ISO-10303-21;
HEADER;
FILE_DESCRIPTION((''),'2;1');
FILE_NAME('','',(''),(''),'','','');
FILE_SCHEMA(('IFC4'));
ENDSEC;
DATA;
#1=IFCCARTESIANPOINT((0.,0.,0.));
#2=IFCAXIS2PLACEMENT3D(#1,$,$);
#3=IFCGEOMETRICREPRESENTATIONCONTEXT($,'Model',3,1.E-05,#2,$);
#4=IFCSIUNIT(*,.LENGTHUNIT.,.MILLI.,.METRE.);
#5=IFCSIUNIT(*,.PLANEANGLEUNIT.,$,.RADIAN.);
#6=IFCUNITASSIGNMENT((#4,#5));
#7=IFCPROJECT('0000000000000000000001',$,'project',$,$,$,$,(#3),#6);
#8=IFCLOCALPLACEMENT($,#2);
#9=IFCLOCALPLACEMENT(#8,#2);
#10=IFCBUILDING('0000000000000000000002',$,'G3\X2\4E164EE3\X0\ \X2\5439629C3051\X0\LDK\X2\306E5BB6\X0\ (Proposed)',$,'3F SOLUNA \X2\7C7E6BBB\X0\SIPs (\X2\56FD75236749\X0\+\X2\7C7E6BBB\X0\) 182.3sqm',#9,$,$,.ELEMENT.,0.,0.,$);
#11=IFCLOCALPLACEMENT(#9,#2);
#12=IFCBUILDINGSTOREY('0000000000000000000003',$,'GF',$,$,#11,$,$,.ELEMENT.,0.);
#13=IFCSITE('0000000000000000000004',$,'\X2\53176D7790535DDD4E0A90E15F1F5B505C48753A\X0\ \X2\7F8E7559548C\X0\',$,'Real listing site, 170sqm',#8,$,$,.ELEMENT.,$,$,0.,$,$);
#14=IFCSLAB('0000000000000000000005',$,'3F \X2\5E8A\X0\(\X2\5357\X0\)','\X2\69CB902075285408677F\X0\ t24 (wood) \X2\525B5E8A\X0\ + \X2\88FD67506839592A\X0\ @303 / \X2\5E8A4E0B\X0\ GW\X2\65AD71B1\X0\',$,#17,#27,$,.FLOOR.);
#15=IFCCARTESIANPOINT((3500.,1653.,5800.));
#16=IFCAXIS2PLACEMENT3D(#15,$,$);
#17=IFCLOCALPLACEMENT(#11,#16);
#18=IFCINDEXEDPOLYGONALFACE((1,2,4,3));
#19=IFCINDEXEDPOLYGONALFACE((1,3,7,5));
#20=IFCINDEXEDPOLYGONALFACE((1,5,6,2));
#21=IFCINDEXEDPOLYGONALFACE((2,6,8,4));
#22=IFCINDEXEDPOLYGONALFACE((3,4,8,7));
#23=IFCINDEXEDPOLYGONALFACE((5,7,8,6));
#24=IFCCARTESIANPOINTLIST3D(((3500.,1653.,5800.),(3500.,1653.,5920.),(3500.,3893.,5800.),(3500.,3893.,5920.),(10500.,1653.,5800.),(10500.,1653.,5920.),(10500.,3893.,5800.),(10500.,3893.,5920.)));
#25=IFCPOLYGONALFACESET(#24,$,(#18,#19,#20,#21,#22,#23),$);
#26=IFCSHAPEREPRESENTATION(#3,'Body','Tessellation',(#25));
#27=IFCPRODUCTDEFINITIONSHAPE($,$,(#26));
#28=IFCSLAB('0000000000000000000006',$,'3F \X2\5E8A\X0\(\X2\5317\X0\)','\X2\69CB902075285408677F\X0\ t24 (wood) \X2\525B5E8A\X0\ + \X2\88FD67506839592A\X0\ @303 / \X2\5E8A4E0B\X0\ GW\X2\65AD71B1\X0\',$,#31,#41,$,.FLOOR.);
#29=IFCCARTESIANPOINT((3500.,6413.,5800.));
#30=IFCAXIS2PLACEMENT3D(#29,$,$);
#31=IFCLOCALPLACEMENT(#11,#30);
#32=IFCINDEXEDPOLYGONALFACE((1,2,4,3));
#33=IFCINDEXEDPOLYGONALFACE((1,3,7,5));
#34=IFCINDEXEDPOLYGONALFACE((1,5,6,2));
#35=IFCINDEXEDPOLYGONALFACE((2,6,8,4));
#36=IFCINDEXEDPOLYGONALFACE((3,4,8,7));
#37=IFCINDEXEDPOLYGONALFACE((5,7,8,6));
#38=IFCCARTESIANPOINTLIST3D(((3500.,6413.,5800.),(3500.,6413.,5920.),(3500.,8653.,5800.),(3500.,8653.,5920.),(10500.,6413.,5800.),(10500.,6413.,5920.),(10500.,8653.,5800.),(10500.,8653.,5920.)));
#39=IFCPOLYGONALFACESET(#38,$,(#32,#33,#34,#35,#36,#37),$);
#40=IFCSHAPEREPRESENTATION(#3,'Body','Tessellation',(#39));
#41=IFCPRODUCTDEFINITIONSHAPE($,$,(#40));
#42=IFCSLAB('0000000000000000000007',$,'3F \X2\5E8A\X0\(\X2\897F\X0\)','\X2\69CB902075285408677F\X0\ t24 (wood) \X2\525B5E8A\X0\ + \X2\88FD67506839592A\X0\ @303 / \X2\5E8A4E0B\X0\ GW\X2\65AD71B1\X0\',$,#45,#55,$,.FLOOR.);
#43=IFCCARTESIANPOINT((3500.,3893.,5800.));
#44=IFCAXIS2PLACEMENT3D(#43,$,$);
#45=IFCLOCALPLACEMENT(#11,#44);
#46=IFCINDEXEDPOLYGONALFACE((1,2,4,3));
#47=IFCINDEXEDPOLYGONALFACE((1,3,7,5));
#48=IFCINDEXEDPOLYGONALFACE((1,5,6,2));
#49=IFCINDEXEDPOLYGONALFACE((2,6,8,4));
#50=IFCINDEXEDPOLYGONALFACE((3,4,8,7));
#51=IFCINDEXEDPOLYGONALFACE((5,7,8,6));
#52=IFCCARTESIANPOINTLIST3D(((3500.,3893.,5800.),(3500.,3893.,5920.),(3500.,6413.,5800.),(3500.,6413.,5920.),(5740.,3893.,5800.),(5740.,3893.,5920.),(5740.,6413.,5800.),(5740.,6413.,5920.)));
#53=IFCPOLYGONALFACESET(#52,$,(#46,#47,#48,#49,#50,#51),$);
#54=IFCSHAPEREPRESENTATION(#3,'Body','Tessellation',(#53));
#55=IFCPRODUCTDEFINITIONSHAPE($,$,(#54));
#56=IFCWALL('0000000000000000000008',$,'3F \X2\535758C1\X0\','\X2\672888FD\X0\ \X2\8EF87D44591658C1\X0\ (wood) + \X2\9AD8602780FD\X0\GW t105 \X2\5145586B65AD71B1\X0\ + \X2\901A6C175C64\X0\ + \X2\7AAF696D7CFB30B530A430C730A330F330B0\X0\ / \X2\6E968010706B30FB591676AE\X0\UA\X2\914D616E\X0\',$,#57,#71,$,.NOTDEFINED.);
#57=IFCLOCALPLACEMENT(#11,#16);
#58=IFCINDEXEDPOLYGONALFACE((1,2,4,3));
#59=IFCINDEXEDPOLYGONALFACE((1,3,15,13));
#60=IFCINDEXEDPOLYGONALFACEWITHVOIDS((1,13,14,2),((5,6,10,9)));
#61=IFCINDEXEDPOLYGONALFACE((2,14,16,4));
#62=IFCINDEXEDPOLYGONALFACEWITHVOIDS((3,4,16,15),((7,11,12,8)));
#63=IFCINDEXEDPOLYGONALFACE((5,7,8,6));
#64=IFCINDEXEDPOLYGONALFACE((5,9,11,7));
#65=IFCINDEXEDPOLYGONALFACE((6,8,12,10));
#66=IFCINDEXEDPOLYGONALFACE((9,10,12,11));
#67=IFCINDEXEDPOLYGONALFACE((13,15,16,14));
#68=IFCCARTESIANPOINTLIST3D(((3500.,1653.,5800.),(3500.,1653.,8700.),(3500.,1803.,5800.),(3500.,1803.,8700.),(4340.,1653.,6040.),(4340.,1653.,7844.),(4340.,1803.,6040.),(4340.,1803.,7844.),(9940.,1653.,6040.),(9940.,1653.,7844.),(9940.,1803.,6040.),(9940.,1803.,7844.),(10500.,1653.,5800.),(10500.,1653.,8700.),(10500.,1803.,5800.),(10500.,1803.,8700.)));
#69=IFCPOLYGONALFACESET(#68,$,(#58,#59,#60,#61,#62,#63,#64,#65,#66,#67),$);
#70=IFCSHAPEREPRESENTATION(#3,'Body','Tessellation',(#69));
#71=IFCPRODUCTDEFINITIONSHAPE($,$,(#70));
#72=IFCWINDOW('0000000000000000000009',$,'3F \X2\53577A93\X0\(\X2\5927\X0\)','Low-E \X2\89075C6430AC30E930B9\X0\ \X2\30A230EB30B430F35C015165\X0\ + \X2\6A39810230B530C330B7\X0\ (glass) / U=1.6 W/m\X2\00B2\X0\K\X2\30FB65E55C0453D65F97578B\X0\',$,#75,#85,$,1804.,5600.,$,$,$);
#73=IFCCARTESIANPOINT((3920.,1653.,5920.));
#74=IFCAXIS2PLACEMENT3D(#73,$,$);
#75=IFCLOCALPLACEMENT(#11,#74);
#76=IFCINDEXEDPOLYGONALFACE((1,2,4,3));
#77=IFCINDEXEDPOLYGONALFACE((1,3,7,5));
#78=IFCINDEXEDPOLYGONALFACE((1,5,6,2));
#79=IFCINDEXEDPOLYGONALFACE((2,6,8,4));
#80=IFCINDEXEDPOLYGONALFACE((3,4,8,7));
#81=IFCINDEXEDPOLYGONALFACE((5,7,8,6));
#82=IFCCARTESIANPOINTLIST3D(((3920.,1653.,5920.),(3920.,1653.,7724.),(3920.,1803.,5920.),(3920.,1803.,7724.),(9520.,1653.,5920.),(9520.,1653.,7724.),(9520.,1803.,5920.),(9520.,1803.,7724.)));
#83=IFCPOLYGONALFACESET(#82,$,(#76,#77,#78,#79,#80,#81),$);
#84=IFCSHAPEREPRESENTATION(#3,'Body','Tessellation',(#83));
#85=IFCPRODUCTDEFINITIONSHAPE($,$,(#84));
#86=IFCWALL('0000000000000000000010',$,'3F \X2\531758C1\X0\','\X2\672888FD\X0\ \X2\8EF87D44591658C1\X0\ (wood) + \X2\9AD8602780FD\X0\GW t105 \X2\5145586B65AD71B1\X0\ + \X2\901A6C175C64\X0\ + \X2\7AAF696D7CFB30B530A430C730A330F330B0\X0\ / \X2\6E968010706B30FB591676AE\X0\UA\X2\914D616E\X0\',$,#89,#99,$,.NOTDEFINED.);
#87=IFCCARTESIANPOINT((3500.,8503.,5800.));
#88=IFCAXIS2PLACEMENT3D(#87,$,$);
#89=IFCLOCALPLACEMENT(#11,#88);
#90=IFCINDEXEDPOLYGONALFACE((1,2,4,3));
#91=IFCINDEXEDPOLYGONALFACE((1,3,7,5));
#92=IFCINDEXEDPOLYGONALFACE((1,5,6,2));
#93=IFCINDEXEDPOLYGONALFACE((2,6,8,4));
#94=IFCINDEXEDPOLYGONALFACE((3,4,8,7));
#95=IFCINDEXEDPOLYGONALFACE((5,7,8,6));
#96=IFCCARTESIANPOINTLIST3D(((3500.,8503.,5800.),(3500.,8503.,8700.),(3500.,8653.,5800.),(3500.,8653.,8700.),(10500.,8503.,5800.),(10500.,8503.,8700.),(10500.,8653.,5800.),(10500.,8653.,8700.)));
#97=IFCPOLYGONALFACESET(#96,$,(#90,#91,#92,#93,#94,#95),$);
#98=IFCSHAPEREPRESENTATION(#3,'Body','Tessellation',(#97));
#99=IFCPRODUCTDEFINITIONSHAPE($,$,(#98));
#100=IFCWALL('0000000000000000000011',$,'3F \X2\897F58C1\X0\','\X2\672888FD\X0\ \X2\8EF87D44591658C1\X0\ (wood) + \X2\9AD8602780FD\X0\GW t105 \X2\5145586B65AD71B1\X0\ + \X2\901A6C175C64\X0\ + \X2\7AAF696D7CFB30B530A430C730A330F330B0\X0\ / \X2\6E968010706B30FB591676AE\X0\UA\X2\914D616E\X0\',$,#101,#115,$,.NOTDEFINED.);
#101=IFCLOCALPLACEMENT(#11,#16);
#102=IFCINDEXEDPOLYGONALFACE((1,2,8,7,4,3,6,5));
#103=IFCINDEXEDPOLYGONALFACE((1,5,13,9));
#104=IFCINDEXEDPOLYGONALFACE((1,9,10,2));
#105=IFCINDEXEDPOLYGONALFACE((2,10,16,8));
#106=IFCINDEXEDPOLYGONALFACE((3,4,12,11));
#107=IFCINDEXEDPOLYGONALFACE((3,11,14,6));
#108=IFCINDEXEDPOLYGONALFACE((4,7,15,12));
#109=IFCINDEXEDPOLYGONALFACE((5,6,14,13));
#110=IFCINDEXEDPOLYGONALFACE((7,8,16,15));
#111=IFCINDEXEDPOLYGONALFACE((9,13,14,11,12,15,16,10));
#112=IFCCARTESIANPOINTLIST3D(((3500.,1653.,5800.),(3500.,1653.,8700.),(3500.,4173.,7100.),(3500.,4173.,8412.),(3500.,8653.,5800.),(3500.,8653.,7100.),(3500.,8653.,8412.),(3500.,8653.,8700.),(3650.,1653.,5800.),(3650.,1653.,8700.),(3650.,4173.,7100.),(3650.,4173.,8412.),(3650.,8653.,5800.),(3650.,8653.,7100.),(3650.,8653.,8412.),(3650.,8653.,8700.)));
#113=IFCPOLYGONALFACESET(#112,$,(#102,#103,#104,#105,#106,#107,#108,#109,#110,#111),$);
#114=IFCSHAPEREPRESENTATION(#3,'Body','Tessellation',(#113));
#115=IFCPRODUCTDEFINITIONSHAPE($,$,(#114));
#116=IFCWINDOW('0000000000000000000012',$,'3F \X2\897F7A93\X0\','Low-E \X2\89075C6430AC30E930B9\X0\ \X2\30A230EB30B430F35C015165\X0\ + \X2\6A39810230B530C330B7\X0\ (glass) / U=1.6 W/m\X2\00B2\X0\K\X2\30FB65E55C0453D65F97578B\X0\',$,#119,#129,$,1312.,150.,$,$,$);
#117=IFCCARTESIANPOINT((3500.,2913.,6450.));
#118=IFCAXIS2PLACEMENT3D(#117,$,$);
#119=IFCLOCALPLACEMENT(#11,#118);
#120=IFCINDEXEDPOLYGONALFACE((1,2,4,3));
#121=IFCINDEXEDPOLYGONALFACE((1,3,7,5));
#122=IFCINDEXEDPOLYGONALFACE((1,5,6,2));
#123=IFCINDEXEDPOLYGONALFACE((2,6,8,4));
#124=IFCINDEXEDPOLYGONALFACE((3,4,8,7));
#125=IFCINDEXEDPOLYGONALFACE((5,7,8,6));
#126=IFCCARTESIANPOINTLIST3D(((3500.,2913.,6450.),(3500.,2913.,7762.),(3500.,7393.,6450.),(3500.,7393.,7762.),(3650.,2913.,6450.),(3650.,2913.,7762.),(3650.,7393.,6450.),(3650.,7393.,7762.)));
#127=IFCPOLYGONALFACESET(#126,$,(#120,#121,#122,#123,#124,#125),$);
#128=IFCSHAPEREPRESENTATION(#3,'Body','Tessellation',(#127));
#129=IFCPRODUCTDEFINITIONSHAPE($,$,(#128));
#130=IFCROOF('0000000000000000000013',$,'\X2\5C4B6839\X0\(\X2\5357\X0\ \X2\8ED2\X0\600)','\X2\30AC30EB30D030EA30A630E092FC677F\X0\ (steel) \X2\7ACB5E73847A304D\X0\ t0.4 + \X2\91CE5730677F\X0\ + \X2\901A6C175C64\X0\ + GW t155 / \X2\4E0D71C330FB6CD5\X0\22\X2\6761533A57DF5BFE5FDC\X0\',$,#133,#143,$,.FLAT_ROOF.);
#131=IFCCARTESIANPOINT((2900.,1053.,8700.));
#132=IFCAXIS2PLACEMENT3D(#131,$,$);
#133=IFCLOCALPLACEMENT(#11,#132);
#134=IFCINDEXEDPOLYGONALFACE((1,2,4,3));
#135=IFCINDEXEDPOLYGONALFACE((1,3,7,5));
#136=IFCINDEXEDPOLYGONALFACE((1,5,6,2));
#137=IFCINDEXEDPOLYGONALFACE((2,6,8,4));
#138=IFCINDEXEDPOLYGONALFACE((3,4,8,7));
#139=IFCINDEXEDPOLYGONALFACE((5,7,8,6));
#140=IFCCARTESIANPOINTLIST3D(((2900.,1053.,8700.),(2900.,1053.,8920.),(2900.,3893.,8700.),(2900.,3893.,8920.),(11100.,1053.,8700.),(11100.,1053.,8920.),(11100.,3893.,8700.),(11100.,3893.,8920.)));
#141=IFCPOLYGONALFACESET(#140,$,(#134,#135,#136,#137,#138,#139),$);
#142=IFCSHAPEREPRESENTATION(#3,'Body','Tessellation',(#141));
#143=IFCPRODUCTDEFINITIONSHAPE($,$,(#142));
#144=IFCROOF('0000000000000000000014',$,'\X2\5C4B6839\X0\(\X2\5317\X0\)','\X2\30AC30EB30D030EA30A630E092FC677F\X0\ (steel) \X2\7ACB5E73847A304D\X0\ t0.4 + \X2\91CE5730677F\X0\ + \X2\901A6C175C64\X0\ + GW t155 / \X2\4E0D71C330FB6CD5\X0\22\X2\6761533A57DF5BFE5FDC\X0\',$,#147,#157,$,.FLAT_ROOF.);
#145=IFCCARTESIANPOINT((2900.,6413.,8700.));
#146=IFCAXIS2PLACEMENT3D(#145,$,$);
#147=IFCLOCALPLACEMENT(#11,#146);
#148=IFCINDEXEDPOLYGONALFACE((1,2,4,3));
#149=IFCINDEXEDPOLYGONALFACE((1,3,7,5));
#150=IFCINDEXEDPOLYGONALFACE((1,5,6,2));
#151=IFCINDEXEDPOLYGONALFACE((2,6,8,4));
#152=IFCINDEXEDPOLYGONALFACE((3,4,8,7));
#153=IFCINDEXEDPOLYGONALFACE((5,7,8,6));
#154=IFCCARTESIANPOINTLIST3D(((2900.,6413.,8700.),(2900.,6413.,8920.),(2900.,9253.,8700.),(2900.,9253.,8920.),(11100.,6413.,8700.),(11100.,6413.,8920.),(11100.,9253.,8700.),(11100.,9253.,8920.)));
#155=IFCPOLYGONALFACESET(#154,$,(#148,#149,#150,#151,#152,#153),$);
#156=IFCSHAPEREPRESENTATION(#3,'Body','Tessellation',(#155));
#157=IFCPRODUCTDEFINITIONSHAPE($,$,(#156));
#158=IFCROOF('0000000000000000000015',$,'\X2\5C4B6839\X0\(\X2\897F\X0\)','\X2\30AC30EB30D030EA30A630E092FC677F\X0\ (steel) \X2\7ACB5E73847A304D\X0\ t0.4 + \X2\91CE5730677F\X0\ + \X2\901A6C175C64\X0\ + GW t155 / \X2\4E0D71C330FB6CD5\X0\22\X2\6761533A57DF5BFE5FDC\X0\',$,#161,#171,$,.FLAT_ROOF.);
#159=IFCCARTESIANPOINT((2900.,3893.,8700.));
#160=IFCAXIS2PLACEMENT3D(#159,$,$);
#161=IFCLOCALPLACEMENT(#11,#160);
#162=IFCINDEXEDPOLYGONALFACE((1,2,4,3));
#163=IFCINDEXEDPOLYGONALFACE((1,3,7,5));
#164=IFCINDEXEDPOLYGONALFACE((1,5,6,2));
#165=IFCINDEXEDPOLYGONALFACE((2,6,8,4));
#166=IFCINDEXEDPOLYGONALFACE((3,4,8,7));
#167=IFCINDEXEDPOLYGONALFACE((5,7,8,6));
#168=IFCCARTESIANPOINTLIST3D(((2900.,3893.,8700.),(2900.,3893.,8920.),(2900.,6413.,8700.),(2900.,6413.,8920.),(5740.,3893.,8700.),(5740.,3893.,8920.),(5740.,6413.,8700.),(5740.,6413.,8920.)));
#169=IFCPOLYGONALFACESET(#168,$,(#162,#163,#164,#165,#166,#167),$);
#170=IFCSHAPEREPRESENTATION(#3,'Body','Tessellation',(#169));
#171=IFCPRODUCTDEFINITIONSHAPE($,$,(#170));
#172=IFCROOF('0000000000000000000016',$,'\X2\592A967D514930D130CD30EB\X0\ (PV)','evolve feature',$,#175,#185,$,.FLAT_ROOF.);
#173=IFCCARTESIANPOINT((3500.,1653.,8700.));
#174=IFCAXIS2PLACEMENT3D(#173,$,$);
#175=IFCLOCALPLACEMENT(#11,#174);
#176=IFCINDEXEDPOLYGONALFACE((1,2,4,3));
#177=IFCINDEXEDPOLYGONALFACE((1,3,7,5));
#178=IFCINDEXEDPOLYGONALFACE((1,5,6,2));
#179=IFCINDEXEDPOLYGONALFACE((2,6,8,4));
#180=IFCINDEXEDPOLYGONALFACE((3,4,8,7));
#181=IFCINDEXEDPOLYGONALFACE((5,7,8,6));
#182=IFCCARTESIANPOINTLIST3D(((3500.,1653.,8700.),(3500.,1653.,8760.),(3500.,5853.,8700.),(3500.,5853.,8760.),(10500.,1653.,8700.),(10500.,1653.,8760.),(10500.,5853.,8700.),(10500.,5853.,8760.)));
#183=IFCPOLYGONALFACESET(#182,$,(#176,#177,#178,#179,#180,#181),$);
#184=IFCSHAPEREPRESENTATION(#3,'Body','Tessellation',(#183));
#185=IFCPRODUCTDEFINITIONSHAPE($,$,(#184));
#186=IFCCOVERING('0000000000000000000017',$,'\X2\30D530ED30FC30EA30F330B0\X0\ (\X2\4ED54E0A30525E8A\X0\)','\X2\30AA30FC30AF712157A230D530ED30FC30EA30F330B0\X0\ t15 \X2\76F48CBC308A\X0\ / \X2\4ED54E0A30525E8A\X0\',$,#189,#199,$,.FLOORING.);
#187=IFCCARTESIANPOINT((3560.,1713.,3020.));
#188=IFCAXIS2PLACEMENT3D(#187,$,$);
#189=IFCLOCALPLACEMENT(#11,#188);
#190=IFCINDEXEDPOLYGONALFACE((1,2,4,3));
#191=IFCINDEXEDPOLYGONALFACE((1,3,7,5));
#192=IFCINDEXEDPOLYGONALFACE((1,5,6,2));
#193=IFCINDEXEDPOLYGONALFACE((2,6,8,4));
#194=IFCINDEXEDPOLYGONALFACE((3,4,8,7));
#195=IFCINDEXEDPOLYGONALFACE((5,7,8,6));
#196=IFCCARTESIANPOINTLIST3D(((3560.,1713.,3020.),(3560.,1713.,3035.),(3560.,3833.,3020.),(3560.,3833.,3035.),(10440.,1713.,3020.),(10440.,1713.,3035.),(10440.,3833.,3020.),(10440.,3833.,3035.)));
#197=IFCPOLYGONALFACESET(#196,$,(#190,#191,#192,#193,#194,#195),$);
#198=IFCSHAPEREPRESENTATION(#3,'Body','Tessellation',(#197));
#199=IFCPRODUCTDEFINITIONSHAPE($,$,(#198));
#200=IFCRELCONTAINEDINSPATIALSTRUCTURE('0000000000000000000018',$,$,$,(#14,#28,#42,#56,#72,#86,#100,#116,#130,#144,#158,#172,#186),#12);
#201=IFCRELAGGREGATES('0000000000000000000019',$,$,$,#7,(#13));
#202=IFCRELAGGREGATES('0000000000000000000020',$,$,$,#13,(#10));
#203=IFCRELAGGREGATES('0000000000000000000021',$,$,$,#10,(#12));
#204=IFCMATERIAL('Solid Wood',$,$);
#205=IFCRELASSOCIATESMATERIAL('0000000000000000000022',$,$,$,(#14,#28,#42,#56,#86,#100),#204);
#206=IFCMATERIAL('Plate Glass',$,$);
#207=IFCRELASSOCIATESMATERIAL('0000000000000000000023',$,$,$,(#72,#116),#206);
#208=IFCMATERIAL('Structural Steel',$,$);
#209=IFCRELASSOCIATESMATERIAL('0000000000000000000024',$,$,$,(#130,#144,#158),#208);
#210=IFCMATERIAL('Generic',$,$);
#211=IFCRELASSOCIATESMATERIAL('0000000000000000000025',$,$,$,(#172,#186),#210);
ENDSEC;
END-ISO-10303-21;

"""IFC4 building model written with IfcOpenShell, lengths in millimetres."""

from ifc_helpers import new_model, si_unit, frame, frame_2d, origin, place, context, project, spatial, rectangle, extrude, material, element, fill, save


model = new_model("IFC4")

# Units and contexts
model_context = context("Model", 3, precision=1e-05, world=origin())
ifc_project = project(units=[si_unit("LENGTHUNIT", "METRE", prefix="MILLI"), si_unit("PLANEANGLEUNIT", "RADIAN")], contexts=[model_context])

# Site, building, storey
site_placement = place(None, origin())
site = spatial("IfcSite", under=ifc_project, at=site_placement, Name="北海道川上郡弟子屈町 美留和", ObjectType="Real listing site, 170sqm", CompositionType="ELEMENT", RefElevation=0.0)
building_placement = place(site_placement, origin())
building = spatial("IfcBuilding", under=site, at=building_placement, Name="G3世代 吹抜けLDKの家 (Proposed)", ObjectType="3F SOLUNA 籾殻SIPs (国産杉+籾殻) 182.3sqm", CompositionType="ELEMENT", ElevationOfRefHeight=0.0, ElevationOfTerrain=0.0)
storey_placement = place(building_placement, origin())
storey = spatial("IfcBuildingStorey", under=building, at=storey_placement, Name="GF", CompositionType="ELEMENT", Elevation=0.0)

# Slabs
ifc_material_1 = material(Name="Solid Wood")
slab_1_placement = place(storey_placement, frame((3500.0, 1653.0, 5800.0)))
element("IfcSlab", 1, at=slab_1_placement, inside=storey, material=ifc_material_1, Name="3F 床(南)", Description="構造用合板 t24 (wood) 剛床 + 製材根太 @303 / 床下 GW断熱", PredefinedType="FLOOR", context=model_context, shape_type="SweptSolid", body=[
    extrude(rectangle(XDim=7000.0, YDim=2240.0, at=frame_2d((3500.0, 1120.0))), frame((3500.0, 1653.0, 5800.0)), (0.0, 0.0, 1.0), 120.0),
])
slab_2_placement = place(storey_placement, frame((3500.0, 6413.0, 5800.0)))
element("IfcSlab", 2, at=slab_2_placement, inside=storey, material=ifc_material_1, Name="3F 床(北)", Description="構造用合板 t24 (wood) 剛床 + 製材根太 @303 / 床下 GW断熱", PredefinedType="FLOOR", context=model_context, shape_type="SweptSolid", body=[
    extrude(rectangle(XDim=7000.0, YDim=2240.0, at=frame_2d((3500.0, 1120.0))), frame((3500.0, 6413.0, 5800.0)), (0.0, 0.0, 1.0), 120.0),
])
slab_3_placement = place(storey_placement, frame((3500.0, 3893.0, 5800.0)))
element("IfcSlab", 3, at=slab_3_placement, inside=storey, material=ifc_material_1, Name="3F 床(西)", Description="構造用合板 t24 (wood) 剛床 + 製材根太 @303 / 床下 GW断熱", PredefinedType="FLOOR", context=model_context, shape_type="SweptSolid", body=[
    extrude(rectangle(XDim=2240.0, YDim=2520.0, at=frame_2d((1120.0, 1260.0))), frame((3500.0, 3893.0, 5800.0)), (0.0, 0.0, 1.0), 120.0),
])

# Wall, opening, window
wall_1_placement = place(storey_placement, frame((3500.0, 1653.0, 5800.0)))
wall_1 = element("IfcWall", 4, at=wall_1_placement, inside=storey, material=ifc_material_1, Name="3F 南壁", Description="木製 軸組外壁 (wood) + 高性能GW t105 充填断熱 + 通気層 + 窯業系サイディング / 準耐火・外皮UA配慮", PredefinedType="NOTDEFINED", context=model_context, shape_type="SweptSolid", body=[
    extrude(rectangle(XDim=7000.0, YDim=150.0, at=frame_2d((3500.0, 75.0))), frame((3500.0, 1653.0, 5800.0)), (0.0, 0.0, 1.0), 2900.0),
])
opening_1_placement = place(storey_placement, frame((3920.0, 1653.0, 5920.0)))
opening_1 = element("IfcOpeningElement", 5, at=opening_1_placement, cuts=wall_1, PredefinedType="NOTDEFINED", context=model_context, shape_type="SweptSolid", body=[
    extrude(rectangle(XDim=5600.0, YDim=150.0, at=frame_2d((2800.0, 75.0))), frame((3920.0, 1653.0, 5920.0)), (0.0, 0.0, 1.0), 1804.0),
])
ifc_material_2 = material(Name="Plate Glass")
window_1_placement = place(storey_placement, frame((3920.0, 1653.0, 5920.0)))
window_1 = element("IfcWindow", 6, at=window_1_placement, inside=storey, material=ifc_material_2, Name="3F 南窓(大)", Description="Low-E 複層ガラス アルゴン封入 + 樹脂サッシ (glass) / U=1.6 W/m²K・日射取得型", OverallHeight=1804.0, OverallWidth=5600.0, context=model_context, shape_type="SweptSolid", body=[
    extrude(rectangle(XDim=5600.0, YDim=150.0, at=frame_2d((2800.0, 75.0))), frame((3920.0, 1653.0, 5920.0)), (0.0, 0.0, 1.0), 1804.0),
])
fill(opening_1, window_1)

# Wall
wall_2_placement = place(storey_placement, frame((3500.0, 8503.0, 5800.0)))
element("IfcWall", 7, at=wall_2_placement, inside=storey, material=ifc_material_1, Name="3F 北壁", Description="木製 軸組外壁 (wood) + 高性能GW t105 充填断熱 + 通気層 + 窯業系サイディング / 準耐火・外皮UA配慮", PredefinedType="NOTDEFINED", context=model_context, shape_type="SweptSolid", body=[
    extrude(rectangle(XDim=7000.0, YDim=150.0, at=frame_2d((3500.0, 75.0))), frame((3500.0, 8503.0, 5800.0)), (0.0, 0.0, 1.0), 2900.0),
])

# Wall, opening, window
wall_3_placement = place(storey_placement, frame((3500.0, 1653.0, 5800.0)))
wall_3 = element("IfcWall", 8, at=wall_3_placement, inside=storey, material=ifc_material_1, Name="3F 西壁", Description="木製 軸組外壁 (wood) + 高性能GW t105 充填断熱 + 通気層 + 窯業系サイディング / 準耐火・外皮UA配慮", PredefinedType="NOTDEFINED", context=model_context, shape_type="SweptSolid", body=[
    extrude(rectangle(XDim=150.0, YDim=7000.0, at=frame_2d((75.0, 3500.0))), frame((3500.0, 1653.0, 5800.0)), (0.0, 0.0, 1.0), 2900.0),
])
opening_2_placement = place(storey_placement, frame((3500.0, 2913.0, 6450.0)))
opening_2 = element("IfcOpeningElement", 9, at=opening_2_placement, cuts=wall_3, PredefinedType="NOTDEFINED", context=model_context, shape_type="SweptSolid", body=[
    extrude(rectangle(XDim=150.0, YDim=4480.0, at=frame_2d((75.0, 2240.0))), frame((3500.0, 2913.0, 6450.0)), (0.0, 0.0, 1.0), 1312.0),
])
window_2_placement = place(storey_placement, frame((3500.0, 2913.0, 6450.0)))
window_2 = element("IfcWindow", 10, at=window_2_placement, inside=storey, material=ifc_material_2, Name="3F 西窓", Description="Low-E 複層ガラス アルゴン封入 + 樹脂サッシ (glass) / U=1.6 W/m²K・日射取得型", OverallHeight=1312.0, OverallWidth=150.0, context=model_context, shape_type="SweptSolid", body=[
    extrude(rectangle(XDim=150.0, YDim=4480.0, at=frame_2d((75.0, 2240.0))), frame((3500.0, 2913.0, 6450.0)), (0.0, 0.0, 1.0), 1312.0),
])
fill(opening_2, window_2)

# Roofs
ifc_material_3 = material(Name="Structural Steel")
roof_1_placement = place(storey_placement, frame((2900.0, 1053.0, 8700.0)))
element("IfcRoof", 11, at=roof_1_placement, inside=storey, material=ifc_material_3, Name="屋根(南 軒600)", Description="ガルバリウム鋼板 (steel) 立平葺き t0.4 + 野地板 + 通気層 + GW t155 / 不燃・法22条区域対応", PredefinedType="FLAT_ROOF", context=model_context, shape_type="SweptSolid", body=[
    extrude(rectangle(XDim=8200.0, YDim=2840.0, at=frame_2d((4100.0, 1420.0))), frame((2900.0, 1053.0, 8700.0)), (0.0, 0.0, 1.0), 220.0),
])
roof_2_placement = place(storey_placement, frame((2900.0, 6413.0, 8700.0)))
element("IfcRoof", 12, at=roof_2_placement, inside=storey, material=ifc_material_3, Name="屋根(北)", Description="ガルバリウム鋼板 (steel) 立平葺き t0.4 + 野地板 + 通気層 + GW t155 / 不燃・法22条区域対応", PredefinedType="FLAT_ROOF", context=model_context, shape_type="SweptSolid", body=[
    extrude(rectangle(XDim=8200.0, YDim=2840.0, at=frame_2d((4100.0, 1420.0))), frame((2900.0, 6413.0, 8700.0)), (0.0, 0.0, 1.0), 220.0),
])
roof_3_placement = place(storey_placement, frame((2900.0, 3893.0, 8700.0)))
element("IfcRoof", 13, at=roof_3_placement, inside=storey, material=ifc_material_3, Name="屋根(西)", Description="ガルバリウム鋼板 (steel) 立平葺き t0.4 + 野地板 + 通気層 + GW t155 / 不燃・法22条区域対応", PredefinedType="FLAT_ROOF", context=model_context, shape_type="SweptSolid", body=[
    extrude(rectangle(XDim=2840.0, YDim=2520.0, at=frame_2d((1420.0, 1260.0))), frame((2900.0, 3893.0, 8700.0)), (0.0, 0.0, 1.0), 220.0),
])
ifc_material_4 = material(Name="Generic")
roof_4_placement = place(storey_placement, frame((3500.0, 1653.0, 8700.0)))
element("IfcRoof", 14, at=roof_4_placement, inside=storey, material=ifc_material_4, Name="太陽光パネル (PV)", Description="evolve feature", PredefinedType="FLAT_ROOF", context=model_context, shape_type="SweptSolid", body=[
    extrude(rectangle(XDim=7000.0, YDim=4200.0, at=frame_2d((3500.0, 2100.0))), frame((3500.0, 1653.0, 8700.0)), (0.0, 0.0, 1.0), 60.0),
])

# Covering
covering_1_placement = place(storey_placement, frame((3560.0, 1713.0, 3020.0)))
element("IfcCovering", 15, at=covering_1_placement, inside=storey, material=ifc_material_4, Name="フローリング (仕上げ床)", Description="オーク無垢フローリング t15 直貼り / 仕上げ床", PredefinedType="FLOORING", context=model_context, shape_type="SweptSolid", body=[
    extrude(rectangle(XDim=6880.0, YDim=2120.0, at=frame_2d((3440.0, 1060.0))), frame((3560.0, 1713.0, 3020.0)), (0.0, 0.0, 1.0), 15.0),
])

save(model, "model.ifc")
